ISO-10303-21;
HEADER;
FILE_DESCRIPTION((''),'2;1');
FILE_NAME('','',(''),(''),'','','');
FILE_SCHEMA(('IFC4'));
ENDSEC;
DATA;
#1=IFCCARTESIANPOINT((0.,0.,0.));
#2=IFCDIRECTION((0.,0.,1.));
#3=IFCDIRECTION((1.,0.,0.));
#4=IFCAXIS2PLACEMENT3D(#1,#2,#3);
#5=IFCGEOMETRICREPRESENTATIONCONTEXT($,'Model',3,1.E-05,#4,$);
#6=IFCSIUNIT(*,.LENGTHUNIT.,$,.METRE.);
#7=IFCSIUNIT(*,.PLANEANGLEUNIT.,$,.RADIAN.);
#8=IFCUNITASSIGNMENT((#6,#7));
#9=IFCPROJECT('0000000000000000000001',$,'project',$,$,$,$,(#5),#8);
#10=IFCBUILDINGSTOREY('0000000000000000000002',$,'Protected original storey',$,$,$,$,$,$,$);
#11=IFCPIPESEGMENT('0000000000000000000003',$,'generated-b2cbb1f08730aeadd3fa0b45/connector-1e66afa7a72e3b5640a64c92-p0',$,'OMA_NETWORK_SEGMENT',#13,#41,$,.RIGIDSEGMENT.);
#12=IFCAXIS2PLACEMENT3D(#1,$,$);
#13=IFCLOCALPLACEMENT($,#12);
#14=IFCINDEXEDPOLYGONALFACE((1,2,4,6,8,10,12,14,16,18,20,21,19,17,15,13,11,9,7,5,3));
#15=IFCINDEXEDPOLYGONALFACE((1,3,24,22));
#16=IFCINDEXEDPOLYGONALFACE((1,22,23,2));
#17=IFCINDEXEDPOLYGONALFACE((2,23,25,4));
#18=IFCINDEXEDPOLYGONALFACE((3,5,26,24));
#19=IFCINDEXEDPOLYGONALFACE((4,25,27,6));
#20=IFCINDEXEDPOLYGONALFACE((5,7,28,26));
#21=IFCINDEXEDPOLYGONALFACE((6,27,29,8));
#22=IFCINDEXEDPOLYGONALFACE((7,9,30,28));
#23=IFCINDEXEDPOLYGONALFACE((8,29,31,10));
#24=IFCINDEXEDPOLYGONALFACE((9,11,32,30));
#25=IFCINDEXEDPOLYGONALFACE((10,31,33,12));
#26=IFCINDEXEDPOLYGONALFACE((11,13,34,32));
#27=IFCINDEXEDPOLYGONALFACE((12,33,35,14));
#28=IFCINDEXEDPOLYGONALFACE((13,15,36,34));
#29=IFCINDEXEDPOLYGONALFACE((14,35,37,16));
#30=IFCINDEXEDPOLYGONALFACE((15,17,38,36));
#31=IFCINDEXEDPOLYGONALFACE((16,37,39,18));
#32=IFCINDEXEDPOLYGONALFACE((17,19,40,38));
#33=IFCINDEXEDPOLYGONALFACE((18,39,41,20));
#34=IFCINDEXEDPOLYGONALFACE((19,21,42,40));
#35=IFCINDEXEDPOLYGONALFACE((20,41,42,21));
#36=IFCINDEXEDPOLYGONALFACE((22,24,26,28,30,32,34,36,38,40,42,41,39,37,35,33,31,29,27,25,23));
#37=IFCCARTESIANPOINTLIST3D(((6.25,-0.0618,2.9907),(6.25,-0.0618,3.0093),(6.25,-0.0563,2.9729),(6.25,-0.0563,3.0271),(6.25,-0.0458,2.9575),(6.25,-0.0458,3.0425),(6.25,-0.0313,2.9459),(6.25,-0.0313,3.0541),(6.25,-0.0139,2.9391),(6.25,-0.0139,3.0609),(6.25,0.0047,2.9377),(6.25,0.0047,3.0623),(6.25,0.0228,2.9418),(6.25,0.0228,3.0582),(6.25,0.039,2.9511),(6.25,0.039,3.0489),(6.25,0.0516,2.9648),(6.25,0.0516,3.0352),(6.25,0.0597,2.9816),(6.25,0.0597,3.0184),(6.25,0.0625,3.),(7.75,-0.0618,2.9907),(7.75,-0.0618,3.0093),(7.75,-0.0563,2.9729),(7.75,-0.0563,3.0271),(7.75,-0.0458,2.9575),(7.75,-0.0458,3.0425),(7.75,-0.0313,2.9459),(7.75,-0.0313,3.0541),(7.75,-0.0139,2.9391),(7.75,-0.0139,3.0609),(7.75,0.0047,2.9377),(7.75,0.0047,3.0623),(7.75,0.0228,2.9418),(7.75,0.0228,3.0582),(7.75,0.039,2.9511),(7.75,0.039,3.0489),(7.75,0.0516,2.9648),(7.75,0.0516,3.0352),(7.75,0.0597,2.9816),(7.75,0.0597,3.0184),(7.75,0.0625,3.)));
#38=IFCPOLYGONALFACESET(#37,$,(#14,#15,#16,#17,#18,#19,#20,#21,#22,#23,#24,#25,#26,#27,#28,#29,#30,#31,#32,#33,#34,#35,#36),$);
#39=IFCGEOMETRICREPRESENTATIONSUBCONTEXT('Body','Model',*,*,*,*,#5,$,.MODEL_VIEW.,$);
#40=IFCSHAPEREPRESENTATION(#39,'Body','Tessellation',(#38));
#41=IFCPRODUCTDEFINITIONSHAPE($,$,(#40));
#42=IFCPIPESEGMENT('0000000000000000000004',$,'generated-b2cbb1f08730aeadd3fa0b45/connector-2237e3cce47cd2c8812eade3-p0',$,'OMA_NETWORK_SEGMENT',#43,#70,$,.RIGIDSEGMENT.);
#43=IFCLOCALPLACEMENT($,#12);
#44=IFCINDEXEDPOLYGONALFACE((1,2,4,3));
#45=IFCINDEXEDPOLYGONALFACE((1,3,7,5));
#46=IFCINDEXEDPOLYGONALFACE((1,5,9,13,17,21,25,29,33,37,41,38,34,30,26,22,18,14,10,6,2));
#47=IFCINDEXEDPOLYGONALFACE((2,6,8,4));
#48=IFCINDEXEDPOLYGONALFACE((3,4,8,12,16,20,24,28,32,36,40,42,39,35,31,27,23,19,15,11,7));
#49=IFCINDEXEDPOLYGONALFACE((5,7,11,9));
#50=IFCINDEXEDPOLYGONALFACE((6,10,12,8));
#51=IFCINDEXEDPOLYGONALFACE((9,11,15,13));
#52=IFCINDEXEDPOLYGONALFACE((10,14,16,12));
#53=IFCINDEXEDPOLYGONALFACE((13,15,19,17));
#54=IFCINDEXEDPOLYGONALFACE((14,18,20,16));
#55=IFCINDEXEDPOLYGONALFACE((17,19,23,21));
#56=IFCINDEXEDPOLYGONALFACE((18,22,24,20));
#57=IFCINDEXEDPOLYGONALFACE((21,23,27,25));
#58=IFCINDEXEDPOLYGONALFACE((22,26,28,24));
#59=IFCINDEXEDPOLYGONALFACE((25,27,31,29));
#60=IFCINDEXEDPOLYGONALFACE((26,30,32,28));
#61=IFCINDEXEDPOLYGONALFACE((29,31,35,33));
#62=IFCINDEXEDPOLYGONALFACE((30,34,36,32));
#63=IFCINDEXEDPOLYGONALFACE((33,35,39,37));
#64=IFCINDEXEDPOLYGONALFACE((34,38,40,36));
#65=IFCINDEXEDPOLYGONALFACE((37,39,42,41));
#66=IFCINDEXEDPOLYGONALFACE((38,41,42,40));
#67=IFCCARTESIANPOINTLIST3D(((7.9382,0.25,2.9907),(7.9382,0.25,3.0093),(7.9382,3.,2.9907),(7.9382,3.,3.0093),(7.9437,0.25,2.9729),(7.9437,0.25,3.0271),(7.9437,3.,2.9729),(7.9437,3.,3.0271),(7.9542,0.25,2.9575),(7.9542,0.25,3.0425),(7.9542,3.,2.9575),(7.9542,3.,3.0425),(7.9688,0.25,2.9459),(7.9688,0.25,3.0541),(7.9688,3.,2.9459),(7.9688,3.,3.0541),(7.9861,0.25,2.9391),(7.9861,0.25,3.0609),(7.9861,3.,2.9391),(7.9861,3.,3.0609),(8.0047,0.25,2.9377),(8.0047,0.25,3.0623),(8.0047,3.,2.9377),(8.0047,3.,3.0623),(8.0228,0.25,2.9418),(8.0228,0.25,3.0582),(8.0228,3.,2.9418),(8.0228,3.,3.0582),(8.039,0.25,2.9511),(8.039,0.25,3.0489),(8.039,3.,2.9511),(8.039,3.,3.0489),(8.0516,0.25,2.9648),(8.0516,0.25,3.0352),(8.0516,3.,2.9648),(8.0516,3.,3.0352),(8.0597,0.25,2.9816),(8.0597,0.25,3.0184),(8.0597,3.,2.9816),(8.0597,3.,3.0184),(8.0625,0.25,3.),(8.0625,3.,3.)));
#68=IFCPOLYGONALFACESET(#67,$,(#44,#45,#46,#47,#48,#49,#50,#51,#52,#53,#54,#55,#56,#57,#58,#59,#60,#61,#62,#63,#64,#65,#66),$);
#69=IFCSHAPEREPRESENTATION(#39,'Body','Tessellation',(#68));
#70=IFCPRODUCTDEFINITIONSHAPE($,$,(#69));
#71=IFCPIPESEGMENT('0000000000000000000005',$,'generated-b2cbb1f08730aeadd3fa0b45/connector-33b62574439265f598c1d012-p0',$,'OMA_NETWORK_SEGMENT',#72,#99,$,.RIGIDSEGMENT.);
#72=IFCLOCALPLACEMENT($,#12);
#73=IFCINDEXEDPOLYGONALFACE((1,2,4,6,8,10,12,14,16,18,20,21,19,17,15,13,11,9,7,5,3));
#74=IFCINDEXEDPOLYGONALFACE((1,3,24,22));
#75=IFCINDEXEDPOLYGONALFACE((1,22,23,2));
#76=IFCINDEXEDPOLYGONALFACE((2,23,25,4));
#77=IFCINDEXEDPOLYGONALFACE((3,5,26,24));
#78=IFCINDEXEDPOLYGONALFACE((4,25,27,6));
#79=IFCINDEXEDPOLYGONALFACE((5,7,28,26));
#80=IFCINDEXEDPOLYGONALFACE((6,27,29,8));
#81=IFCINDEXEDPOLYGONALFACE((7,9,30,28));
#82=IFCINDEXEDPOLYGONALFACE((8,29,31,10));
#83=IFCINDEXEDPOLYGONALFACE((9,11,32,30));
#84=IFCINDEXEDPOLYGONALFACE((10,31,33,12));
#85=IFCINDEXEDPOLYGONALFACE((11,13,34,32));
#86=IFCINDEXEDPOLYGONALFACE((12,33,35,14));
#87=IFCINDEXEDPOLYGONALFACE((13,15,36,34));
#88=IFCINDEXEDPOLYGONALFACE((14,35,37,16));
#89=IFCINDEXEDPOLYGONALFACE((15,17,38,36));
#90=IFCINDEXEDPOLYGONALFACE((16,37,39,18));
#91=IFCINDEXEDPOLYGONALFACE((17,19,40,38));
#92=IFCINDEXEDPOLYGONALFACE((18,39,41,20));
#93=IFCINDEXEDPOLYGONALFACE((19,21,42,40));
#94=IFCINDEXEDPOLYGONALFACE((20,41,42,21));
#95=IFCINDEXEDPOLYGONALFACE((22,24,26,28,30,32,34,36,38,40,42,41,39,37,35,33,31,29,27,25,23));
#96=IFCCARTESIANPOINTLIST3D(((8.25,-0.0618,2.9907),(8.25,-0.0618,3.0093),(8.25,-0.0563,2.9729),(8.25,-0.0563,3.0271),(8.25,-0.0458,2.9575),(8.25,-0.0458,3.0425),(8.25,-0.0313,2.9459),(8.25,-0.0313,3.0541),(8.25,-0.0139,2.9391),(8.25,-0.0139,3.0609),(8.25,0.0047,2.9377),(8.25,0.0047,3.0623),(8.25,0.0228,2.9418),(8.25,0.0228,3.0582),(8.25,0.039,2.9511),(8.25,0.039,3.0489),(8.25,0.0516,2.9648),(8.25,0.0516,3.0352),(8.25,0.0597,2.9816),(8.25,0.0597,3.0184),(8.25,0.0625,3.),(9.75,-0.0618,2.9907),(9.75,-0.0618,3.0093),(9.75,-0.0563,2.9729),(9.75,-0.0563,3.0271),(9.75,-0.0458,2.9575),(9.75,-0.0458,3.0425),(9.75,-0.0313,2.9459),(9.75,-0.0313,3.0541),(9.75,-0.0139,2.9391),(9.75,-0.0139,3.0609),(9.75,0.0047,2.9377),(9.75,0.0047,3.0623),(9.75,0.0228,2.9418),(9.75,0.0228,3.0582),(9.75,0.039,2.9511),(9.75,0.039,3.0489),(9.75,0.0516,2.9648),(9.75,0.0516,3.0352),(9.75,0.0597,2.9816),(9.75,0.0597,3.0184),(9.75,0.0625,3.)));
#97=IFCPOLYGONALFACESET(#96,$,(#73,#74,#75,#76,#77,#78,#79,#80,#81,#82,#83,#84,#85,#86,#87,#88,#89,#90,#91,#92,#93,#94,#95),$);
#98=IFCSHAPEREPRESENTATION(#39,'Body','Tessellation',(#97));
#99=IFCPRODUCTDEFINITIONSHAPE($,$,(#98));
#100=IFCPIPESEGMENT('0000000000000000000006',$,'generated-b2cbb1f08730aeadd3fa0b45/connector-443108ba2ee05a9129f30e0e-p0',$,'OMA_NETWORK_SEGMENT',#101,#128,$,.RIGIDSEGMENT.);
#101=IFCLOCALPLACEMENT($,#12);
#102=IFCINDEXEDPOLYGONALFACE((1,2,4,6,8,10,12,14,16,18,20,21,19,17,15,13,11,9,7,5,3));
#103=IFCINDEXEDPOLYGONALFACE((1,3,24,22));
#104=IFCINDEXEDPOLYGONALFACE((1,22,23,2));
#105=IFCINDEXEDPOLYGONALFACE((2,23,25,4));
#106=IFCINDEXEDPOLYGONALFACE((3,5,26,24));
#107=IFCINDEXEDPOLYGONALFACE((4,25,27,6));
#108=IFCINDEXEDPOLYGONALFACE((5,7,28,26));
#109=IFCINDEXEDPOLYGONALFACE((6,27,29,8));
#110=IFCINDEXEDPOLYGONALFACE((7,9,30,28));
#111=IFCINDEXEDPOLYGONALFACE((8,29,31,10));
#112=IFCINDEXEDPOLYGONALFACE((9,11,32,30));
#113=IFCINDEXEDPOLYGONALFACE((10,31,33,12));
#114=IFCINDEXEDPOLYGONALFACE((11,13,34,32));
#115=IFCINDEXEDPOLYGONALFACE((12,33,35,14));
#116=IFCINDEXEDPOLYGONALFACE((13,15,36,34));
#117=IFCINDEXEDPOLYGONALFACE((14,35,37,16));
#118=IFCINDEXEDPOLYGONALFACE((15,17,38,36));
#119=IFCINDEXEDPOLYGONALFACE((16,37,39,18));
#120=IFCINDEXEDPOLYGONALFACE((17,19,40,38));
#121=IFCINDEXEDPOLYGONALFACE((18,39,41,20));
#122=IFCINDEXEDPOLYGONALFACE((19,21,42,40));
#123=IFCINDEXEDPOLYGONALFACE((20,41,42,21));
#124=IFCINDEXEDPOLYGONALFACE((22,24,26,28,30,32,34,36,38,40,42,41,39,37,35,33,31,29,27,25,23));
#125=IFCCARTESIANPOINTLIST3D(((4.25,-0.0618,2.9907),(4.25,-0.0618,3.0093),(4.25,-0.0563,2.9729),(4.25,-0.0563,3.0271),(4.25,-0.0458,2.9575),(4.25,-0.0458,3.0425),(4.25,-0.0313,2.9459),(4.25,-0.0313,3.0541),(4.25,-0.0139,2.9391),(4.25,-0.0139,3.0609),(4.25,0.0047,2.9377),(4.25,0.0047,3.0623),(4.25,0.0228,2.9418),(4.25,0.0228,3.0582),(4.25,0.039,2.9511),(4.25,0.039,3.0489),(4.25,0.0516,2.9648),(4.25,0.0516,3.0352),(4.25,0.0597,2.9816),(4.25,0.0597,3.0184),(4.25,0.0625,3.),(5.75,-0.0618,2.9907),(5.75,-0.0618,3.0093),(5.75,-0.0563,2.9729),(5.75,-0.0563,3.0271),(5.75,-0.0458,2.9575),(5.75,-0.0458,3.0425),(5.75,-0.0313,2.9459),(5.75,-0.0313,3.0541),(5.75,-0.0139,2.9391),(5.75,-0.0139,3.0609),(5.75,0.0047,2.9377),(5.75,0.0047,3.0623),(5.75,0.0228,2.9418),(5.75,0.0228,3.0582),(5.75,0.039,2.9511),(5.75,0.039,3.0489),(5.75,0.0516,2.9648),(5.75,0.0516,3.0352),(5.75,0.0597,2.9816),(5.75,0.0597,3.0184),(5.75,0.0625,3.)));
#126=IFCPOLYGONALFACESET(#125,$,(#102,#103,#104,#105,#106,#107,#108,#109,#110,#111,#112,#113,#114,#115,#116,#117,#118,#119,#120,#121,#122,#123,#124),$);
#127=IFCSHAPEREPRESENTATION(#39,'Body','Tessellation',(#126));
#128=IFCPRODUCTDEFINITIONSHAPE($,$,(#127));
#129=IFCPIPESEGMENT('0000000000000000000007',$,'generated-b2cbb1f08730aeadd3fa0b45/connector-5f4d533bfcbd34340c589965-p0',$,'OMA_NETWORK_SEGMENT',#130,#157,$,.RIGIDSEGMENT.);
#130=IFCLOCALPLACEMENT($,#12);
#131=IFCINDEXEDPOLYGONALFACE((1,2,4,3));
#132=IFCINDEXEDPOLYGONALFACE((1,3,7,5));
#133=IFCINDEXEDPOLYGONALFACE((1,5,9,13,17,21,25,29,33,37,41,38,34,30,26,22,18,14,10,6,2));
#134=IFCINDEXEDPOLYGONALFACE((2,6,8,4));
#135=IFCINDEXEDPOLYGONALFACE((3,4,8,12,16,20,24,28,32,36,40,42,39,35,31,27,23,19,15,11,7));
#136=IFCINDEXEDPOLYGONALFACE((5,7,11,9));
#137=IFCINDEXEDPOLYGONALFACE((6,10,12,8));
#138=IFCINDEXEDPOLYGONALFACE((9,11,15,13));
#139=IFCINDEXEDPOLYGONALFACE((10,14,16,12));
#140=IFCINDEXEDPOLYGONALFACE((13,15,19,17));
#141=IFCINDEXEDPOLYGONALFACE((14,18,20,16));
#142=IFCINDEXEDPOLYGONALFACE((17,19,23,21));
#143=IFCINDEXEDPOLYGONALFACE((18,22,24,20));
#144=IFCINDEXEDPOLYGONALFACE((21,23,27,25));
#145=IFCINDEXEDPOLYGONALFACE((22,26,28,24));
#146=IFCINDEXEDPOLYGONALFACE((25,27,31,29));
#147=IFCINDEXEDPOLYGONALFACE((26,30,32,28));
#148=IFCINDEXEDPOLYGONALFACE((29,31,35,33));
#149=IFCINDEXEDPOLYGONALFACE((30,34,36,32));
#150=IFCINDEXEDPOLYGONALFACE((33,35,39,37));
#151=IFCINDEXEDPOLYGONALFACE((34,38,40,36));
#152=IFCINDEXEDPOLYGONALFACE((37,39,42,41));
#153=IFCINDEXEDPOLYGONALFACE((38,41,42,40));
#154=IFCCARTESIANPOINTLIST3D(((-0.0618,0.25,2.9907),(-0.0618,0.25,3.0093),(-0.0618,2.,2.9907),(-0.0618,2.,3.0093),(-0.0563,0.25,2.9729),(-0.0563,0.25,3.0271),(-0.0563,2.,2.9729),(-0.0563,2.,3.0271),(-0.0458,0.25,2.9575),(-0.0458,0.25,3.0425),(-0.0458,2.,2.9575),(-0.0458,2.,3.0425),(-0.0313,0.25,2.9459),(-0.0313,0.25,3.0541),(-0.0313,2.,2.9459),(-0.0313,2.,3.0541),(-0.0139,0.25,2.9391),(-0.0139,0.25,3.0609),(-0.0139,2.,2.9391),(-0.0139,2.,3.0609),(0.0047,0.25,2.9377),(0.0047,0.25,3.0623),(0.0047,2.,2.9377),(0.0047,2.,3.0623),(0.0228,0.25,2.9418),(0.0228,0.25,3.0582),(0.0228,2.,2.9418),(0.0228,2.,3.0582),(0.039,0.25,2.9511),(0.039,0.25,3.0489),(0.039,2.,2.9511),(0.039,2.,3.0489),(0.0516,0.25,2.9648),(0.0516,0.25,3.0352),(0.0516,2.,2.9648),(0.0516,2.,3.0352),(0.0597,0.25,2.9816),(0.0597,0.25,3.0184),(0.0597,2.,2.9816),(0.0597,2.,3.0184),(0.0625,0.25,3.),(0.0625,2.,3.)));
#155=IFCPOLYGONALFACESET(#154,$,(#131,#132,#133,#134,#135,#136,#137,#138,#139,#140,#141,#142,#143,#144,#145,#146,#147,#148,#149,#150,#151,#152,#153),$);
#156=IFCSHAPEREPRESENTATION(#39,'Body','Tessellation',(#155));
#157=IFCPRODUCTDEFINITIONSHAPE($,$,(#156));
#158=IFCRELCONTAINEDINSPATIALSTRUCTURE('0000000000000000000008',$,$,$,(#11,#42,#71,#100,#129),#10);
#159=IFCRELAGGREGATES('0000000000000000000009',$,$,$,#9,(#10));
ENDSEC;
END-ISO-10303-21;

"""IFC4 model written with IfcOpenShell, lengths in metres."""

from ifc_helpers import new_model, si_unit, frame, origin_with_axes, origin_2d, place, context, subcontext, project, spatial, circle, extrude, element, save


model = new_model("IFC4")

# Units and contexts
model_context = context("Model", 3, precision=1e-05, world=origin_with_axes())
body_context = subcontext(model_context, "Body", "Model", "MODEL_VIEW")
ifc_project = project(units=[si_unit("LENGTHUNIT", "METRE"), si_unit("PLANEANGLEUNIT", "RADIAN")], contexts=[model_context])

# Storey
storey = spatial("IfcBuildingStorey", under=ifc_project, Name="Protected original storey")

# Pipe segments
pipe_segment_1_placement = place(None, origin_with_axes())
element("IfcPipeSegment", 1, at=pipe_segment_1_placement, inside=storey, Name="generated-b2cbb1f08730aeadd3fa0b45/connector-1e66afa7a72e3b5640a64c92-p0", ObjectType="OMA_NETWORK_SEGMENT", PredefinedType="RIGIDSEGMENT", context=body_context, shape_type="SweptSolid", body=[
    extrude(circle(Radius=0.0625, at=origin_2d()), frame((6.25, 0.0, 3.0), z_axis=(1.0, 0.0, 0.0), x_axis=(0.0, 1.0, 0.0)), (0.0, 0.0, 1.0), 1.5),
])
pipe_segment_2_placement = place(None, origin_with_axes())
element("IfcPipeSegment", 2, at=pipe_segment_2_placement, inside=storey, Name="generated-b2cbb1f08730aeadd3fa0b45/connector-2237e3cce47cd2c8812eade3-p0", ObjectType="OMA_NETWORK_SEGMENT", PredefinedType="RIGIDSEGMENT", context=body_context, shape_type="SweptSolid", body=[
    extrude(circle(Radius=0.0625, at=origin_2d()), frame((8.0, 0.25, 3.0), z_axis=(0.0, 1.0, 0.0), x_axis=(1.0, 0.0, 0.0)), (0.0, 0.0, 1.0), 2.75),
])
pipe_segment_3_placement = place(None, origin_with_axes())
element("IfcPipeSegment", 3, at=pipe_segment_3_placement, inside=storey, Name="generated-b2cbb1f08730aeadd3fa0b45/connector-33b62574439265f598c1d012-p0", ObjectType="OMA_NETWORK_SEGMENT", PredefinedType="RIGIDSEGMENT", context=body_context, shape_type="SweptSolid", body=[
    extrude(circle(Radius=0.0625, at=origin_2d()), frame((8.25, 0.0, 3.0), z_axis=(1.0, 0.0, 0.0), x_axis=(0.0, 1.0, 0.0)), (0.0, 0.0, 1.0), 1.5),
])
pipe_segment_4_placement = place(None, origin_with_axes())
element("IfcPipeSegment", 4, at=pipe_segment_4_placement, inside=storey, Name="generated-b2cbb1f08730aeadd3fa0b45/connector-443108ba2ee05a9129f30e0e-p0", ObjectType="OMA_NETWORK_SEGMENT", PredefinedType="RIGIDSEGMENT", context=body_context, shape_type="SweptSolid", body=[
    extrude(circle(Radius=0.0625, at=origin_2d()), frame((4.25, 0.0, 3.0), z_axis=(1.0, 0.0, 0.0), x_axis=(0.0, 1.0, 0.0)), (0.0, 0.0, 1.0), 1.5),
])
pipe_segment_5_placement = place(None, origin_with_axes())
element("IfcPipeSegment", 5, at=pipe_segment_5_placement, inside=storey, Name="generated-b2cbb1f08730aeadd3fa0b45/connector-5f4d533bfcbd34340c589965-p0", ObjectType="OMA_NETWORK_SEGMENT", PredefinedType="RIGIDSEGMENT", context=body_context, shape_type="SweptSolid", body=[
    extrude(circle(Radius=0.0625, at=origin_2d()), frame((0.0, 0.25, 3.0), z_axis=(0.0, 1.0, 0.0), x_axis=(1.0, 0.0, 0.0)), (0.0, 0.0, 1.0), 1.75),
])

save(model, "model.ifc")
